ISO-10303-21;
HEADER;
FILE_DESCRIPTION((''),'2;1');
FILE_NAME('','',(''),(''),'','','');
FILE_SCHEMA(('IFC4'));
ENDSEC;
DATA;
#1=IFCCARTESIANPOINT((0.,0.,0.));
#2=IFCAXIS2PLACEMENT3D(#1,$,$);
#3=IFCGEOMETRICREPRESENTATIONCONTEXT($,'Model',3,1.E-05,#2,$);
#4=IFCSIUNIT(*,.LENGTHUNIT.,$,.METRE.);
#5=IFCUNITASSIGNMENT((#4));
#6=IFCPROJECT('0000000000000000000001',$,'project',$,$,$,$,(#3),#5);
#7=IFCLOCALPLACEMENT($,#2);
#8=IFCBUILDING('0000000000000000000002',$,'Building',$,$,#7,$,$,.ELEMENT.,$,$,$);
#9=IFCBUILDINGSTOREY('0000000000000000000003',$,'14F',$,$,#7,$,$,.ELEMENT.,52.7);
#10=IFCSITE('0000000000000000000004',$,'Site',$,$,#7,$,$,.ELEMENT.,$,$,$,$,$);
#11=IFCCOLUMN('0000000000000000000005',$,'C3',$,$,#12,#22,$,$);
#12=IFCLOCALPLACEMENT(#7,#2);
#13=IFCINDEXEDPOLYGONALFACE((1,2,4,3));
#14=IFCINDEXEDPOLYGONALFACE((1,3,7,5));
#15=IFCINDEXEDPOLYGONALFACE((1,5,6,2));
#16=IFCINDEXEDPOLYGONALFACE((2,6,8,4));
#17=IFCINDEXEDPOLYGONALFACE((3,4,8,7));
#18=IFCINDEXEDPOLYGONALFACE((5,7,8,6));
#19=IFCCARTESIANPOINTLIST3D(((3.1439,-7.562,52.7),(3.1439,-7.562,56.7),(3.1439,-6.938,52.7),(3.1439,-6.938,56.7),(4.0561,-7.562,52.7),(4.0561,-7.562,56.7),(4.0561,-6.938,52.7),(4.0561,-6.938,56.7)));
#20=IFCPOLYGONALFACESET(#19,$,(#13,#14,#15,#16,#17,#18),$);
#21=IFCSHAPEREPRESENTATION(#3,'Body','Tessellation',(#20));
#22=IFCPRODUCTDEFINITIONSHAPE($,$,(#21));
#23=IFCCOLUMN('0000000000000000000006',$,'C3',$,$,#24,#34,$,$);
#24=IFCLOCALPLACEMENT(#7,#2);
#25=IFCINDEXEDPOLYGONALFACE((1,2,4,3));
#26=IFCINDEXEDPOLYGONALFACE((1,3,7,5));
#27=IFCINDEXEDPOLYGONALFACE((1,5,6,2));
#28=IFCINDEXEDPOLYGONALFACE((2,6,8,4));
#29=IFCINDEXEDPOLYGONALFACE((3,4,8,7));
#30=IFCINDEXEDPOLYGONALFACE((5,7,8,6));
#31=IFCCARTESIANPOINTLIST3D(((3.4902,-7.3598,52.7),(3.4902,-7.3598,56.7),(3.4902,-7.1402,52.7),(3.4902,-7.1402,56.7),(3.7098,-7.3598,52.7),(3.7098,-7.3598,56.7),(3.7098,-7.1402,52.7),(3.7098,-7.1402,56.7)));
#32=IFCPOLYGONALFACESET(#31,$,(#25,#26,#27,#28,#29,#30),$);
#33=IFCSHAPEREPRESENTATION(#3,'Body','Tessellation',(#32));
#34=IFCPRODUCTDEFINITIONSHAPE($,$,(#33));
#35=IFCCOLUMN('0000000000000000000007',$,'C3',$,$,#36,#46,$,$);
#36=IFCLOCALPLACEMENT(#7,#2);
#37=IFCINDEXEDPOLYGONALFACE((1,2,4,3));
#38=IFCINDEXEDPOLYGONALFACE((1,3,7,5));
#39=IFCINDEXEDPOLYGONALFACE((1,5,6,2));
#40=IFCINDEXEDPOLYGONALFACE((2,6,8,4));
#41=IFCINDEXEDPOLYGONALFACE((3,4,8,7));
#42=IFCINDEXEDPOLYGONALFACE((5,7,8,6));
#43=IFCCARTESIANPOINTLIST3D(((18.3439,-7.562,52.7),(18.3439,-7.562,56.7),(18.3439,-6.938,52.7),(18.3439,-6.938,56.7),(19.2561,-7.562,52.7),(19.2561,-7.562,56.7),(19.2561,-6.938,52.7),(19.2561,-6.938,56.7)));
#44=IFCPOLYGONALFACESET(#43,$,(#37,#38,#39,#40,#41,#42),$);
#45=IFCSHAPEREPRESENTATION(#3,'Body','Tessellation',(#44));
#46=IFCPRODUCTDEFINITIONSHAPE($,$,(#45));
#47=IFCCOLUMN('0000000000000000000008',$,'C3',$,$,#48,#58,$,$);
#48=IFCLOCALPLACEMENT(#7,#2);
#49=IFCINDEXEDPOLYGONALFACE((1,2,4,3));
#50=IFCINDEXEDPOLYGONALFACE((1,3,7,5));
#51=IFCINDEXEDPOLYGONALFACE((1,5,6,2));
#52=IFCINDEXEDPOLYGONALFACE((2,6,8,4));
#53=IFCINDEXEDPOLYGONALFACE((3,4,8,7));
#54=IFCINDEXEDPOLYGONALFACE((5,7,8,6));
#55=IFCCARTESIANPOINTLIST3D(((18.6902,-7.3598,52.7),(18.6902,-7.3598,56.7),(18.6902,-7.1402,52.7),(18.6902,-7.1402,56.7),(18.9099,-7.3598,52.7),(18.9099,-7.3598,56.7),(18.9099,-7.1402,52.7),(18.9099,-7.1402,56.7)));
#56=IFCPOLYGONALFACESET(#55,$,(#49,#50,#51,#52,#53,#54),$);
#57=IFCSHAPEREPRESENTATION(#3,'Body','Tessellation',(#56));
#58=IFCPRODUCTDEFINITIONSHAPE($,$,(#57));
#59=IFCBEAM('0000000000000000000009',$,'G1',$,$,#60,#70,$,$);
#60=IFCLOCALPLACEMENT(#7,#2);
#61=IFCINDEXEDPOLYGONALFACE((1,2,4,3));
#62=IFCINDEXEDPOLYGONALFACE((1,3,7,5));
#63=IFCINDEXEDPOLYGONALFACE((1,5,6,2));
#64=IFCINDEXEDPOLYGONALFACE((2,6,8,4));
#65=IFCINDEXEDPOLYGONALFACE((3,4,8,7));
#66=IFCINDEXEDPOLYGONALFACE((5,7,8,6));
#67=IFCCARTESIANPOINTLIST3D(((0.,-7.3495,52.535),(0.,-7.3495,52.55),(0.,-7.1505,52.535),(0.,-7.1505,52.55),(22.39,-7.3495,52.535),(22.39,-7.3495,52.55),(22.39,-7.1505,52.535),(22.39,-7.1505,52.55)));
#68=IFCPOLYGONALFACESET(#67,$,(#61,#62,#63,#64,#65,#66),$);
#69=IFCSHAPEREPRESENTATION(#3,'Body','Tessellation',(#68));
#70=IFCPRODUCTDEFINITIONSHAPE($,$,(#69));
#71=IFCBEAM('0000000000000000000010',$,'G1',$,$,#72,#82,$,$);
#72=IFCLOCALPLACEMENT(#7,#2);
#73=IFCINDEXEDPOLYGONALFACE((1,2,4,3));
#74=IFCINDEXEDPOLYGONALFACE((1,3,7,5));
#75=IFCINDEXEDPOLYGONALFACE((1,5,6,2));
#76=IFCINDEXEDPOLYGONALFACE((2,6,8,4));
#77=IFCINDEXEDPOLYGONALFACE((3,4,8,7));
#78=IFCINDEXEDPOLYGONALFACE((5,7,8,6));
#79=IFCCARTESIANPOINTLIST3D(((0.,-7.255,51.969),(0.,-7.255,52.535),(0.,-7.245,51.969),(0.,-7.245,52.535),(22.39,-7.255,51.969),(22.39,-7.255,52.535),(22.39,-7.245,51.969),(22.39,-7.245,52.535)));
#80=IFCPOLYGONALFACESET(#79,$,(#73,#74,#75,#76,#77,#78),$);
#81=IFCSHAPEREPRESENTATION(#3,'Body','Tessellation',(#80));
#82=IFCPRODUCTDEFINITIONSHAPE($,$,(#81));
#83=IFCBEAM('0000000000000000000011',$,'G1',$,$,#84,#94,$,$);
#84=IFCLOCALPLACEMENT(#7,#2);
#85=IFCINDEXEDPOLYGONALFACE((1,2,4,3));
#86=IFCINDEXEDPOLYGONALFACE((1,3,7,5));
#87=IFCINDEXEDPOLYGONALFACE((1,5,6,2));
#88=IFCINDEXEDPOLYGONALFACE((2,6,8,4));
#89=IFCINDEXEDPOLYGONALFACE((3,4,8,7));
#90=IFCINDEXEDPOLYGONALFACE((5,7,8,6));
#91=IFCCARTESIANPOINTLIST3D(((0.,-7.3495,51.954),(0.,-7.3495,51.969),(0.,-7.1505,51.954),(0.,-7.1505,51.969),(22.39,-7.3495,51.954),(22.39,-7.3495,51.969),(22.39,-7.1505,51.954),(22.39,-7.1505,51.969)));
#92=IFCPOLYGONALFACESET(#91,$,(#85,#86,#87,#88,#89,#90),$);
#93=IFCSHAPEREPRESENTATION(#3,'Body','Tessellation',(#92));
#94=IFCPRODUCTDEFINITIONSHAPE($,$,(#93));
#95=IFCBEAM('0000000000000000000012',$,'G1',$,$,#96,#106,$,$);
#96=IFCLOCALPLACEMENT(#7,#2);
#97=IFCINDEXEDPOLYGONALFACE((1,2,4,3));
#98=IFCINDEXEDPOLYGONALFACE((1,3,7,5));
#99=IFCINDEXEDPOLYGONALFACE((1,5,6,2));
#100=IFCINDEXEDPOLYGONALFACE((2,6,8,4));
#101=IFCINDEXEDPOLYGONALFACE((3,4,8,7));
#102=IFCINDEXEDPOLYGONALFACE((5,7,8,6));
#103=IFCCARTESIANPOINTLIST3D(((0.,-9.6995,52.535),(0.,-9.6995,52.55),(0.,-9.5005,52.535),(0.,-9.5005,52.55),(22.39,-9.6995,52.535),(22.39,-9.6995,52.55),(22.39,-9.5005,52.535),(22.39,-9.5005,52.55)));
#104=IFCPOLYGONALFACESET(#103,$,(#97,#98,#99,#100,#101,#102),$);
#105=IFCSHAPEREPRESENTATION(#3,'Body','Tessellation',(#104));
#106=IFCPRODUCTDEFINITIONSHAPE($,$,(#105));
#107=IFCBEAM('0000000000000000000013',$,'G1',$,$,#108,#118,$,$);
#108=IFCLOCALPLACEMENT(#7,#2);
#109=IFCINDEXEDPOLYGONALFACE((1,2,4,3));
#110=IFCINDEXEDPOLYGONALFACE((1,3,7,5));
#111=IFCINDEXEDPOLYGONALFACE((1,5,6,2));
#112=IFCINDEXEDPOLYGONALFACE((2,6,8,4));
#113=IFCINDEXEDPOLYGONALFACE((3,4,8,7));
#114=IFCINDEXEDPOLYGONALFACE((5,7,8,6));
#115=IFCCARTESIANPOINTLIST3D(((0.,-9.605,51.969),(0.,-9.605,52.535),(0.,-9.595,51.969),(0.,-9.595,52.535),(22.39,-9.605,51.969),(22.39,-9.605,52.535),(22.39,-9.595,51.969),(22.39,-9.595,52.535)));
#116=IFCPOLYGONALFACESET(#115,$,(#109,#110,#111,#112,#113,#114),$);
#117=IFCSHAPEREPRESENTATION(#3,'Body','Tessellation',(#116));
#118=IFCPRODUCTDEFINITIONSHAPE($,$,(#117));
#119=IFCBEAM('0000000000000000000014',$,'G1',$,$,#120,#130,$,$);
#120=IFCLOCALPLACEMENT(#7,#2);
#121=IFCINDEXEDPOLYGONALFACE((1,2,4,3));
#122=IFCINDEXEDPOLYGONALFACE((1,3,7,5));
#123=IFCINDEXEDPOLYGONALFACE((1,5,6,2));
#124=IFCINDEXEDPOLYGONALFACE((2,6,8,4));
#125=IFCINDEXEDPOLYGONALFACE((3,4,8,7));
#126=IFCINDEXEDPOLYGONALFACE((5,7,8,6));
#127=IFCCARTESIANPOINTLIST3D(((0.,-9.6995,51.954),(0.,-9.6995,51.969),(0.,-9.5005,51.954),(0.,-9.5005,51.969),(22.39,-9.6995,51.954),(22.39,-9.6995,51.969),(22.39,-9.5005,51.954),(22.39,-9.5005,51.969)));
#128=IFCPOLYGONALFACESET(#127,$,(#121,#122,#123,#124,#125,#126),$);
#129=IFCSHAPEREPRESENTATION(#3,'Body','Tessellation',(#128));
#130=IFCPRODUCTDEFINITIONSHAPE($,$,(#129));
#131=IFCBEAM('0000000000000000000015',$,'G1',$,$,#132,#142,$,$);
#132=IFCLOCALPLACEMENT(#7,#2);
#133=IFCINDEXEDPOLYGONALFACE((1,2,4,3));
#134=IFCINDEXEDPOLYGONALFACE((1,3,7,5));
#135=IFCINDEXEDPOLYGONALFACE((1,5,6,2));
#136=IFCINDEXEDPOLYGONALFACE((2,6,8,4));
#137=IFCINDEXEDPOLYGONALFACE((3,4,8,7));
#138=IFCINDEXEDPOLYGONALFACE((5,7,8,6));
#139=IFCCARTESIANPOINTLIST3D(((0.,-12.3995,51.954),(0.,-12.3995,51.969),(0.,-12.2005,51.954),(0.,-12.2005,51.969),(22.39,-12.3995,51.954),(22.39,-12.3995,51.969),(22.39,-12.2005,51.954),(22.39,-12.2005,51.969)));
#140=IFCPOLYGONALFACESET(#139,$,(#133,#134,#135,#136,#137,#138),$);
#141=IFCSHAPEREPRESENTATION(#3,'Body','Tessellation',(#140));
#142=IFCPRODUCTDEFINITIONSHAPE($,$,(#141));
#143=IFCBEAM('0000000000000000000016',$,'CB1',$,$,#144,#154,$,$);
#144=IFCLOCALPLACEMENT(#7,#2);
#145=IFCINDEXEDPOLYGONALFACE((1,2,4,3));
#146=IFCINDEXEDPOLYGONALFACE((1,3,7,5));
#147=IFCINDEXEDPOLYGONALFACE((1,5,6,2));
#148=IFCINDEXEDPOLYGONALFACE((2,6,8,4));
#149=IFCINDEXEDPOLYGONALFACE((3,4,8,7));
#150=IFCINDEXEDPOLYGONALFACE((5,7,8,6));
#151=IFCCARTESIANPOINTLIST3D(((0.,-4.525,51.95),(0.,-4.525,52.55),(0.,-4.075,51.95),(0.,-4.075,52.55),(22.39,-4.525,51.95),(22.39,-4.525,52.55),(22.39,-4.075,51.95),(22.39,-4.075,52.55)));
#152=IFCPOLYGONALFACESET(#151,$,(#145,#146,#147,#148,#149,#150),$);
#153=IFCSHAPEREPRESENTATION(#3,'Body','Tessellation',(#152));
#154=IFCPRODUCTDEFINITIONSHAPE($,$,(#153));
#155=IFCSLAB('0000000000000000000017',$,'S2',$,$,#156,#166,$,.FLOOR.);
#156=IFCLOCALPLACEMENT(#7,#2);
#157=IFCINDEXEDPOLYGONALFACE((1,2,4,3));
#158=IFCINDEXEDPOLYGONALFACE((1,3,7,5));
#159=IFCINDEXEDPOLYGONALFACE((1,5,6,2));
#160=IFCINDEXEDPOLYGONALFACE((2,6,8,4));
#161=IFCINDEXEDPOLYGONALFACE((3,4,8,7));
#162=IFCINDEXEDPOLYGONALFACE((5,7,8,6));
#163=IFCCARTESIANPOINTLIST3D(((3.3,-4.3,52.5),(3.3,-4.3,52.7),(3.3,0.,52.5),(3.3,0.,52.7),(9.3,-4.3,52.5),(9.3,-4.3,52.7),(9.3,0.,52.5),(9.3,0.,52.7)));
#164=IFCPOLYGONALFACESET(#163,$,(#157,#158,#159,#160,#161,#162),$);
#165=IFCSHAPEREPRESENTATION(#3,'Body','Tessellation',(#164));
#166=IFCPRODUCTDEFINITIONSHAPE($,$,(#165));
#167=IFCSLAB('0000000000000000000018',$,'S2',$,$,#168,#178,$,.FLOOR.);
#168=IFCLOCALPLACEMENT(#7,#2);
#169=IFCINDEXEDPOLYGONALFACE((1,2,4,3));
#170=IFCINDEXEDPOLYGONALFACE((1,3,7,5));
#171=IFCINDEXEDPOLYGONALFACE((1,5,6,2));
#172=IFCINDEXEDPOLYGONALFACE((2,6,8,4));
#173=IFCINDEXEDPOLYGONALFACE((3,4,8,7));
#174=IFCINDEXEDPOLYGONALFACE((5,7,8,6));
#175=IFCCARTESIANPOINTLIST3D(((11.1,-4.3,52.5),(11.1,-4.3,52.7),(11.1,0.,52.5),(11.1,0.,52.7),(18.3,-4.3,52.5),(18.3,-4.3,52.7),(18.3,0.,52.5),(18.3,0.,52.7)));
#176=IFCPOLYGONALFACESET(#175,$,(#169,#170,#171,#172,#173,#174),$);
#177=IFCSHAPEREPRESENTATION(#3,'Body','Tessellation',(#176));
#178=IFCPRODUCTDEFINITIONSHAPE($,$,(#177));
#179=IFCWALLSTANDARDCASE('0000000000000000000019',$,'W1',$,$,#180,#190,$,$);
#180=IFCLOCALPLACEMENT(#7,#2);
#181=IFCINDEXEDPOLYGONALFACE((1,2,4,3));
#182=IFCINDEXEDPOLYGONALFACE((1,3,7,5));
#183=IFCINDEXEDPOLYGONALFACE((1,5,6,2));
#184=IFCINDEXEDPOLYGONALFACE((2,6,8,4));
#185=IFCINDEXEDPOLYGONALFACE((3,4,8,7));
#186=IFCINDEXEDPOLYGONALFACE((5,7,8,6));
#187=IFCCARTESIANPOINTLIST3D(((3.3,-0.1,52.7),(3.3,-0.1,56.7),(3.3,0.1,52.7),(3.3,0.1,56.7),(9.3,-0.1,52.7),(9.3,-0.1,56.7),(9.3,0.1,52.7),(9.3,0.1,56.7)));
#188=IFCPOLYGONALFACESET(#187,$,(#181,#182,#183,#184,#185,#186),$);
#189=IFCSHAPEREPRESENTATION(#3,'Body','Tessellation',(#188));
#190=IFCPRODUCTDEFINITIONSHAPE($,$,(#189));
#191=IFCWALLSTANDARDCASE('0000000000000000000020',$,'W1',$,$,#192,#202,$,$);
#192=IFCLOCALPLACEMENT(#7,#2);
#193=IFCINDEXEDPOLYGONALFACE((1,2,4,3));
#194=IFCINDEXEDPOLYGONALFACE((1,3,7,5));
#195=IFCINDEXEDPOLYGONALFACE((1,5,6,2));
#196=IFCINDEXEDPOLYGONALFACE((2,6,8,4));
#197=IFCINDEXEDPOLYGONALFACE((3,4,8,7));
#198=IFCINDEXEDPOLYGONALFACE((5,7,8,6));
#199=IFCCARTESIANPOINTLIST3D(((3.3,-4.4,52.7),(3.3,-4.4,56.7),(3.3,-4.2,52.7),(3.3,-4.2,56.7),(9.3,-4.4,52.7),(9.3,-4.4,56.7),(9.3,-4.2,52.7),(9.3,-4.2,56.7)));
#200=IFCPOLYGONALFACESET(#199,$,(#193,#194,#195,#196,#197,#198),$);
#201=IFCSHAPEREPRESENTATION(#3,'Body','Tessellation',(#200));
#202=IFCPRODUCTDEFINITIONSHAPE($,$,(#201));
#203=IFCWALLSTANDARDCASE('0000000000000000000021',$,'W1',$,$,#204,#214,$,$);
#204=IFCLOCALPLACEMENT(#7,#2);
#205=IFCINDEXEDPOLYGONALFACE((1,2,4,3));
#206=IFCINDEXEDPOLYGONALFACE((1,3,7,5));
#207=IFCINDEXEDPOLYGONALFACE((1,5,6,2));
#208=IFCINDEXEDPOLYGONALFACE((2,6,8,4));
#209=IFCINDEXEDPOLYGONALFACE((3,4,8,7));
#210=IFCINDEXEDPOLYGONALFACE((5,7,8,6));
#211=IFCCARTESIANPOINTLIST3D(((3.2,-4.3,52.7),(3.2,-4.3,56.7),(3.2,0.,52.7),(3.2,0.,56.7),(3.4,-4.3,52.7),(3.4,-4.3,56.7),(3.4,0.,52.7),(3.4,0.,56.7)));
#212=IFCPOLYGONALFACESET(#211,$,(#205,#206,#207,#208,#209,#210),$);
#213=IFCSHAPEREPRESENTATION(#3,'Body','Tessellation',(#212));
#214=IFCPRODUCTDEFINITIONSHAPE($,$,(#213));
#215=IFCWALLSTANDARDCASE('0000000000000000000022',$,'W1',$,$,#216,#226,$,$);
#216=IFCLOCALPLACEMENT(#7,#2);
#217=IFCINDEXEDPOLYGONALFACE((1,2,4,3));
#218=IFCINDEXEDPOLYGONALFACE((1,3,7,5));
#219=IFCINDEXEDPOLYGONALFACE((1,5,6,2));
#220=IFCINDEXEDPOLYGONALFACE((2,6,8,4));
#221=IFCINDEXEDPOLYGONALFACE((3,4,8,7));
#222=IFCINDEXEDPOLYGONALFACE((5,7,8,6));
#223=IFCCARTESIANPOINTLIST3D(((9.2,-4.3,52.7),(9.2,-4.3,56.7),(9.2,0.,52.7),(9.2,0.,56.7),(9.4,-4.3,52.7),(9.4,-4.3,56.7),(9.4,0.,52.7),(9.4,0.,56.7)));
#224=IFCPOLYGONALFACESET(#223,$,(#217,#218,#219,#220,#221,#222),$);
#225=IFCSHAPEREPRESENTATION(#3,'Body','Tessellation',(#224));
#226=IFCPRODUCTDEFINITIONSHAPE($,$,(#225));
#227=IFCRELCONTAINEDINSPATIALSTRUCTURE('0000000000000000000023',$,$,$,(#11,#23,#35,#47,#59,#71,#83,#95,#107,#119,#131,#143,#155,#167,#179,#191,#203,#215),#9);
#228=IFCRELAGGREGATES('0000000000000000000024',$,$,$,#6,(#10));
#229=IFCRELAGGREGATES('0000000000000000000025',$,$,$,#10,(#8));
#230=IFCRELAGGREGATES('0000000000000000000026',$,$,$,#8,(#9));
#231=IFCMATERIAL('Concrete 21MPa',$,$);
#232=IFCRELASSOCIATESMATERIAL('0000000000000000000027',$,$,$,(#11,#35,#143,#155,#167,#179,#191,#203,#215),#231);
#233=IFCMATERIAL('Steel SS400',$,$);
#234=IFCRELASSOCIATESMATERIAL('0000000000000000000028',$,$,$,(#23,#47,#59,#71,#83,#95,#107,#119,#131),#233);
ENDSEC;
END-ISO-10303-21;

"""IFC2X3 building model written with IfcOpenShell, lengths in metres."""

from ifc_helpers import new_model, si_unit, frame, origin, origin_2d, place, context, project, spatial, rectangle, extrude, material, element, save


model = new_model("IFC2X3")

# Units and contexts
model_context = context("Model", 3, precision=1e-05, world=origin())
ifc_project = project(units=[si_unit("LENGTHUNIT", "METRE")], contexts=[model_context])

# Site, building, storey
placement = place(None, origin())
site = spatial("IfcSite", under=ifc_project, at=placement, Name="Site", CompositionType="ELEMENT")
building = spatial("IfcBuilding", under=site, at=placement, Name="Building", CompositionType="ELEMENT")
storey = spatial("IfcBuildingStorey", under=building, at=placement, Name="14F", CompositionType="ELEMENT", Elevation=52.7)

# Columns
ifc_material_1 = material(Name="Concrete 21MPa")
column_1_placement = place(None, frame((3.6, -7.25, 52.7)))
element("IfcColumn", 1, at=column_1_placement, inside=storey, material=ifc_material_1, Name="C3", context=model_context, shape_type="SweptSolid", body=[
    extrude(rectangle(XDim=0.9121, YDim=0.6241, at=origin_2d()), origin(), (0.0, 0.0, 1.0), 4.0),
])
ifc_material_2 = material(Name="Steel SS400")
column_2_placement = place(None, frame((3.6, -7.25, 52.7)))
element("IfcColumn", 2, at=column_2_placement, inside=storey, material=ifc_material_2, Name="C3", context=model_context, shape_type="SweptSolid", body=[
    extrude(rectangle(XDim=0.2197, YDim=0.2197, at=origin_2d()), origin(), (0.0, 0.0, 1.0), 4.0),
])
column_3_placement = place(None, frame((18.8, -7.25, 52.7)))
element("IfcColumn", 3, at=column_3_placement, inside=storey, material=ifc_material_1, Name="C3", context=model_context, shape_type="SweptSolid", body=[
    extrude(rectangle(XDim=0.9121, YDim=0.6241, at=origin_2d()), origin(), (0.0, 0.0, 1.0), 4.0),
])
column_4_placement = place(None, frame((18.8, -7.25, 52.7)))
element("IfcColumn", 4, at=column_4_placement, inside=storey, material=ifc_material_2, Name="C3", context=model_context, shape_type="SweptSolid", body=[
    extrude(rectangle(XDim=0.2197, YDim=0.2197, at=origin_2d()), origin(), (0.0, 0.0, 1.0), 4.0),
])

# Beams
beam_1_placement = place(None, frame((11.195, -7.25, 52.535)))
element("IfcBeam", 5, at=beam_1_placement, inside=storey, material=ifc_material_2, Name="G1", context=model_context, shape_type="SweptSolid", body=[
    extrude(rectangle(XDim=22.39, YDim=0.199, at=origin_2d()), origin(), (0.0, 0.0, 1.0), 0.015),
])
beam_2_placement = place(None, frame((11.195, -7.25, 51.969)))
element("IfcBeam", 6, at=beam_2_placement, inside=storey, material=ifc_material_2, Name="G1", context=model_context, shape_type="SweptSolid", body=[
    extrude(rectangle(XDim=22.39, YDim=0.01, at=origin_2d()), origin(), (0.0, 0.0, 1.0), 0.566),
])
for number, where, name in (
    (7, (11.195, -7.25, 51.954), "G1"),
    (8, (11.195, -9.6, 52.535), "G1"),
):
    element("IfcBeam", number, at=place(None, frame(where)), inside=storey, material=ifc_material_2, Name=name, context=model_context, shape_type="SweptSolid", body=[
        extrude(rectangle(XDim=22.39, YDim=0.199, at=origin_2d()), origin(), (0.0, 0.0, 1.0), 0.015),
    ])
beam_3_placement = place(None, frame((11.195, -9.6, 51.969)))
element("IfcBeam", 9, at=beam_3_placement, inside=storey, material=ifc_material_2, Name="G1", context=model_context, shape_type="SweptSolid", body=[
    extrude(rectangle(XDim=22.39, YDim=0.01, at=origin_2d()), origin(), (0.0, 0.0, 1.0), 0.566),
])
for number, where, name in (
    (10, (11.195, -9.6, 51.954), "G1"),
    (11, (11.195, -12.3, 51.954), "G1"),
):
    element("IfcBeam", number, at=place(None, frame(where)), inside=storey, material=ifc_material_2, Name=name, context=model_context, shape_type="SweptSolid", body=[
        extrude(rectangle(XDim=22.39, YDim=0.199, at=origin_2d()), origin(), (0.0, 0.0, 1.0), 0.015),
    ])
beam_4_placement = place(None, frame((11.195, -4.3, 51.95)))
element("IfcBeam", 12, at=beam_4_placement, inside=storey, material=ifc_material_1, Name="CB1", context=model_context, shape_type="SweptSolid", body=[
    extrude(rectangle(XDim=22.39, YDim=0.45, at=origin_2d()), origin(), (0.0, 0.0, 1.0), 0.6),
])

# Slabs
slab_1_placement = place(None, frame((6.3, -2.15, 52.5)))
element("IfcSlab", 13, at=slab_1_placement, inside=storey, material=ifc_material_1, Name="S2", PredefinedType="FLOOR", context=model_context, shape_type="SweptSolid", body=[
    extrude(rectangle(XDim=6.0, YDim=4.3, at=origin_2d()), origin(), (0.0, 0.0, 1.0), 0.2),
])
slab_2_placement = place(None, frame((14.7, -2.15, 52.5)))
element("IfcSlab", 14, at=slab_2_placement, inside=storey, material=ifc_material_1, Name="S2", PredefinedType="FLOOR", context=model_context, shape_type="SweptSolid", body=[
    extrude(rectangle(XDim=7.2, YDim=4.3, at=origin_2d()), origin(), (0.0, 0.0, 1.0), 0.2),
])

# Walls
for number, where, name in (
    (15, (6.3, 0.0, 52.7), "W1"),
    (16, (6.3, -4.3, 52.7), "W1"),
):
    element("IfcWallStandardCase", number, at=place(None, frame(where)), inside=storey, material=ifc_material_1, Name=name, context=model_context, shape_type="SweptSolid", body=[
        extrude(rectangle(XDim=6.0, YDim=0.2, at=origin_2d()), origin(), (0.0, 0.0, 1.0), 4.0),
    ])
for number, where, name in (
    (17, (3.3, -2.15, 52.7), "W1"),
    (18, (9.3, -2.15, 52.7), "W1"),
):
    element("IfcWallStandardCase", number, at=place(None, frame(where)), inside=storey, material=ifc_material_1, Name=name, context=model_context, shape_type="SweptSolid", body=[
        extrude(rectangle(XDim=0.2, YDim=4.3, at=origin_2d()), origin(), (0.0, 0.0, 1.0), 4.0),
    ])

save(model, "model.ifc")
